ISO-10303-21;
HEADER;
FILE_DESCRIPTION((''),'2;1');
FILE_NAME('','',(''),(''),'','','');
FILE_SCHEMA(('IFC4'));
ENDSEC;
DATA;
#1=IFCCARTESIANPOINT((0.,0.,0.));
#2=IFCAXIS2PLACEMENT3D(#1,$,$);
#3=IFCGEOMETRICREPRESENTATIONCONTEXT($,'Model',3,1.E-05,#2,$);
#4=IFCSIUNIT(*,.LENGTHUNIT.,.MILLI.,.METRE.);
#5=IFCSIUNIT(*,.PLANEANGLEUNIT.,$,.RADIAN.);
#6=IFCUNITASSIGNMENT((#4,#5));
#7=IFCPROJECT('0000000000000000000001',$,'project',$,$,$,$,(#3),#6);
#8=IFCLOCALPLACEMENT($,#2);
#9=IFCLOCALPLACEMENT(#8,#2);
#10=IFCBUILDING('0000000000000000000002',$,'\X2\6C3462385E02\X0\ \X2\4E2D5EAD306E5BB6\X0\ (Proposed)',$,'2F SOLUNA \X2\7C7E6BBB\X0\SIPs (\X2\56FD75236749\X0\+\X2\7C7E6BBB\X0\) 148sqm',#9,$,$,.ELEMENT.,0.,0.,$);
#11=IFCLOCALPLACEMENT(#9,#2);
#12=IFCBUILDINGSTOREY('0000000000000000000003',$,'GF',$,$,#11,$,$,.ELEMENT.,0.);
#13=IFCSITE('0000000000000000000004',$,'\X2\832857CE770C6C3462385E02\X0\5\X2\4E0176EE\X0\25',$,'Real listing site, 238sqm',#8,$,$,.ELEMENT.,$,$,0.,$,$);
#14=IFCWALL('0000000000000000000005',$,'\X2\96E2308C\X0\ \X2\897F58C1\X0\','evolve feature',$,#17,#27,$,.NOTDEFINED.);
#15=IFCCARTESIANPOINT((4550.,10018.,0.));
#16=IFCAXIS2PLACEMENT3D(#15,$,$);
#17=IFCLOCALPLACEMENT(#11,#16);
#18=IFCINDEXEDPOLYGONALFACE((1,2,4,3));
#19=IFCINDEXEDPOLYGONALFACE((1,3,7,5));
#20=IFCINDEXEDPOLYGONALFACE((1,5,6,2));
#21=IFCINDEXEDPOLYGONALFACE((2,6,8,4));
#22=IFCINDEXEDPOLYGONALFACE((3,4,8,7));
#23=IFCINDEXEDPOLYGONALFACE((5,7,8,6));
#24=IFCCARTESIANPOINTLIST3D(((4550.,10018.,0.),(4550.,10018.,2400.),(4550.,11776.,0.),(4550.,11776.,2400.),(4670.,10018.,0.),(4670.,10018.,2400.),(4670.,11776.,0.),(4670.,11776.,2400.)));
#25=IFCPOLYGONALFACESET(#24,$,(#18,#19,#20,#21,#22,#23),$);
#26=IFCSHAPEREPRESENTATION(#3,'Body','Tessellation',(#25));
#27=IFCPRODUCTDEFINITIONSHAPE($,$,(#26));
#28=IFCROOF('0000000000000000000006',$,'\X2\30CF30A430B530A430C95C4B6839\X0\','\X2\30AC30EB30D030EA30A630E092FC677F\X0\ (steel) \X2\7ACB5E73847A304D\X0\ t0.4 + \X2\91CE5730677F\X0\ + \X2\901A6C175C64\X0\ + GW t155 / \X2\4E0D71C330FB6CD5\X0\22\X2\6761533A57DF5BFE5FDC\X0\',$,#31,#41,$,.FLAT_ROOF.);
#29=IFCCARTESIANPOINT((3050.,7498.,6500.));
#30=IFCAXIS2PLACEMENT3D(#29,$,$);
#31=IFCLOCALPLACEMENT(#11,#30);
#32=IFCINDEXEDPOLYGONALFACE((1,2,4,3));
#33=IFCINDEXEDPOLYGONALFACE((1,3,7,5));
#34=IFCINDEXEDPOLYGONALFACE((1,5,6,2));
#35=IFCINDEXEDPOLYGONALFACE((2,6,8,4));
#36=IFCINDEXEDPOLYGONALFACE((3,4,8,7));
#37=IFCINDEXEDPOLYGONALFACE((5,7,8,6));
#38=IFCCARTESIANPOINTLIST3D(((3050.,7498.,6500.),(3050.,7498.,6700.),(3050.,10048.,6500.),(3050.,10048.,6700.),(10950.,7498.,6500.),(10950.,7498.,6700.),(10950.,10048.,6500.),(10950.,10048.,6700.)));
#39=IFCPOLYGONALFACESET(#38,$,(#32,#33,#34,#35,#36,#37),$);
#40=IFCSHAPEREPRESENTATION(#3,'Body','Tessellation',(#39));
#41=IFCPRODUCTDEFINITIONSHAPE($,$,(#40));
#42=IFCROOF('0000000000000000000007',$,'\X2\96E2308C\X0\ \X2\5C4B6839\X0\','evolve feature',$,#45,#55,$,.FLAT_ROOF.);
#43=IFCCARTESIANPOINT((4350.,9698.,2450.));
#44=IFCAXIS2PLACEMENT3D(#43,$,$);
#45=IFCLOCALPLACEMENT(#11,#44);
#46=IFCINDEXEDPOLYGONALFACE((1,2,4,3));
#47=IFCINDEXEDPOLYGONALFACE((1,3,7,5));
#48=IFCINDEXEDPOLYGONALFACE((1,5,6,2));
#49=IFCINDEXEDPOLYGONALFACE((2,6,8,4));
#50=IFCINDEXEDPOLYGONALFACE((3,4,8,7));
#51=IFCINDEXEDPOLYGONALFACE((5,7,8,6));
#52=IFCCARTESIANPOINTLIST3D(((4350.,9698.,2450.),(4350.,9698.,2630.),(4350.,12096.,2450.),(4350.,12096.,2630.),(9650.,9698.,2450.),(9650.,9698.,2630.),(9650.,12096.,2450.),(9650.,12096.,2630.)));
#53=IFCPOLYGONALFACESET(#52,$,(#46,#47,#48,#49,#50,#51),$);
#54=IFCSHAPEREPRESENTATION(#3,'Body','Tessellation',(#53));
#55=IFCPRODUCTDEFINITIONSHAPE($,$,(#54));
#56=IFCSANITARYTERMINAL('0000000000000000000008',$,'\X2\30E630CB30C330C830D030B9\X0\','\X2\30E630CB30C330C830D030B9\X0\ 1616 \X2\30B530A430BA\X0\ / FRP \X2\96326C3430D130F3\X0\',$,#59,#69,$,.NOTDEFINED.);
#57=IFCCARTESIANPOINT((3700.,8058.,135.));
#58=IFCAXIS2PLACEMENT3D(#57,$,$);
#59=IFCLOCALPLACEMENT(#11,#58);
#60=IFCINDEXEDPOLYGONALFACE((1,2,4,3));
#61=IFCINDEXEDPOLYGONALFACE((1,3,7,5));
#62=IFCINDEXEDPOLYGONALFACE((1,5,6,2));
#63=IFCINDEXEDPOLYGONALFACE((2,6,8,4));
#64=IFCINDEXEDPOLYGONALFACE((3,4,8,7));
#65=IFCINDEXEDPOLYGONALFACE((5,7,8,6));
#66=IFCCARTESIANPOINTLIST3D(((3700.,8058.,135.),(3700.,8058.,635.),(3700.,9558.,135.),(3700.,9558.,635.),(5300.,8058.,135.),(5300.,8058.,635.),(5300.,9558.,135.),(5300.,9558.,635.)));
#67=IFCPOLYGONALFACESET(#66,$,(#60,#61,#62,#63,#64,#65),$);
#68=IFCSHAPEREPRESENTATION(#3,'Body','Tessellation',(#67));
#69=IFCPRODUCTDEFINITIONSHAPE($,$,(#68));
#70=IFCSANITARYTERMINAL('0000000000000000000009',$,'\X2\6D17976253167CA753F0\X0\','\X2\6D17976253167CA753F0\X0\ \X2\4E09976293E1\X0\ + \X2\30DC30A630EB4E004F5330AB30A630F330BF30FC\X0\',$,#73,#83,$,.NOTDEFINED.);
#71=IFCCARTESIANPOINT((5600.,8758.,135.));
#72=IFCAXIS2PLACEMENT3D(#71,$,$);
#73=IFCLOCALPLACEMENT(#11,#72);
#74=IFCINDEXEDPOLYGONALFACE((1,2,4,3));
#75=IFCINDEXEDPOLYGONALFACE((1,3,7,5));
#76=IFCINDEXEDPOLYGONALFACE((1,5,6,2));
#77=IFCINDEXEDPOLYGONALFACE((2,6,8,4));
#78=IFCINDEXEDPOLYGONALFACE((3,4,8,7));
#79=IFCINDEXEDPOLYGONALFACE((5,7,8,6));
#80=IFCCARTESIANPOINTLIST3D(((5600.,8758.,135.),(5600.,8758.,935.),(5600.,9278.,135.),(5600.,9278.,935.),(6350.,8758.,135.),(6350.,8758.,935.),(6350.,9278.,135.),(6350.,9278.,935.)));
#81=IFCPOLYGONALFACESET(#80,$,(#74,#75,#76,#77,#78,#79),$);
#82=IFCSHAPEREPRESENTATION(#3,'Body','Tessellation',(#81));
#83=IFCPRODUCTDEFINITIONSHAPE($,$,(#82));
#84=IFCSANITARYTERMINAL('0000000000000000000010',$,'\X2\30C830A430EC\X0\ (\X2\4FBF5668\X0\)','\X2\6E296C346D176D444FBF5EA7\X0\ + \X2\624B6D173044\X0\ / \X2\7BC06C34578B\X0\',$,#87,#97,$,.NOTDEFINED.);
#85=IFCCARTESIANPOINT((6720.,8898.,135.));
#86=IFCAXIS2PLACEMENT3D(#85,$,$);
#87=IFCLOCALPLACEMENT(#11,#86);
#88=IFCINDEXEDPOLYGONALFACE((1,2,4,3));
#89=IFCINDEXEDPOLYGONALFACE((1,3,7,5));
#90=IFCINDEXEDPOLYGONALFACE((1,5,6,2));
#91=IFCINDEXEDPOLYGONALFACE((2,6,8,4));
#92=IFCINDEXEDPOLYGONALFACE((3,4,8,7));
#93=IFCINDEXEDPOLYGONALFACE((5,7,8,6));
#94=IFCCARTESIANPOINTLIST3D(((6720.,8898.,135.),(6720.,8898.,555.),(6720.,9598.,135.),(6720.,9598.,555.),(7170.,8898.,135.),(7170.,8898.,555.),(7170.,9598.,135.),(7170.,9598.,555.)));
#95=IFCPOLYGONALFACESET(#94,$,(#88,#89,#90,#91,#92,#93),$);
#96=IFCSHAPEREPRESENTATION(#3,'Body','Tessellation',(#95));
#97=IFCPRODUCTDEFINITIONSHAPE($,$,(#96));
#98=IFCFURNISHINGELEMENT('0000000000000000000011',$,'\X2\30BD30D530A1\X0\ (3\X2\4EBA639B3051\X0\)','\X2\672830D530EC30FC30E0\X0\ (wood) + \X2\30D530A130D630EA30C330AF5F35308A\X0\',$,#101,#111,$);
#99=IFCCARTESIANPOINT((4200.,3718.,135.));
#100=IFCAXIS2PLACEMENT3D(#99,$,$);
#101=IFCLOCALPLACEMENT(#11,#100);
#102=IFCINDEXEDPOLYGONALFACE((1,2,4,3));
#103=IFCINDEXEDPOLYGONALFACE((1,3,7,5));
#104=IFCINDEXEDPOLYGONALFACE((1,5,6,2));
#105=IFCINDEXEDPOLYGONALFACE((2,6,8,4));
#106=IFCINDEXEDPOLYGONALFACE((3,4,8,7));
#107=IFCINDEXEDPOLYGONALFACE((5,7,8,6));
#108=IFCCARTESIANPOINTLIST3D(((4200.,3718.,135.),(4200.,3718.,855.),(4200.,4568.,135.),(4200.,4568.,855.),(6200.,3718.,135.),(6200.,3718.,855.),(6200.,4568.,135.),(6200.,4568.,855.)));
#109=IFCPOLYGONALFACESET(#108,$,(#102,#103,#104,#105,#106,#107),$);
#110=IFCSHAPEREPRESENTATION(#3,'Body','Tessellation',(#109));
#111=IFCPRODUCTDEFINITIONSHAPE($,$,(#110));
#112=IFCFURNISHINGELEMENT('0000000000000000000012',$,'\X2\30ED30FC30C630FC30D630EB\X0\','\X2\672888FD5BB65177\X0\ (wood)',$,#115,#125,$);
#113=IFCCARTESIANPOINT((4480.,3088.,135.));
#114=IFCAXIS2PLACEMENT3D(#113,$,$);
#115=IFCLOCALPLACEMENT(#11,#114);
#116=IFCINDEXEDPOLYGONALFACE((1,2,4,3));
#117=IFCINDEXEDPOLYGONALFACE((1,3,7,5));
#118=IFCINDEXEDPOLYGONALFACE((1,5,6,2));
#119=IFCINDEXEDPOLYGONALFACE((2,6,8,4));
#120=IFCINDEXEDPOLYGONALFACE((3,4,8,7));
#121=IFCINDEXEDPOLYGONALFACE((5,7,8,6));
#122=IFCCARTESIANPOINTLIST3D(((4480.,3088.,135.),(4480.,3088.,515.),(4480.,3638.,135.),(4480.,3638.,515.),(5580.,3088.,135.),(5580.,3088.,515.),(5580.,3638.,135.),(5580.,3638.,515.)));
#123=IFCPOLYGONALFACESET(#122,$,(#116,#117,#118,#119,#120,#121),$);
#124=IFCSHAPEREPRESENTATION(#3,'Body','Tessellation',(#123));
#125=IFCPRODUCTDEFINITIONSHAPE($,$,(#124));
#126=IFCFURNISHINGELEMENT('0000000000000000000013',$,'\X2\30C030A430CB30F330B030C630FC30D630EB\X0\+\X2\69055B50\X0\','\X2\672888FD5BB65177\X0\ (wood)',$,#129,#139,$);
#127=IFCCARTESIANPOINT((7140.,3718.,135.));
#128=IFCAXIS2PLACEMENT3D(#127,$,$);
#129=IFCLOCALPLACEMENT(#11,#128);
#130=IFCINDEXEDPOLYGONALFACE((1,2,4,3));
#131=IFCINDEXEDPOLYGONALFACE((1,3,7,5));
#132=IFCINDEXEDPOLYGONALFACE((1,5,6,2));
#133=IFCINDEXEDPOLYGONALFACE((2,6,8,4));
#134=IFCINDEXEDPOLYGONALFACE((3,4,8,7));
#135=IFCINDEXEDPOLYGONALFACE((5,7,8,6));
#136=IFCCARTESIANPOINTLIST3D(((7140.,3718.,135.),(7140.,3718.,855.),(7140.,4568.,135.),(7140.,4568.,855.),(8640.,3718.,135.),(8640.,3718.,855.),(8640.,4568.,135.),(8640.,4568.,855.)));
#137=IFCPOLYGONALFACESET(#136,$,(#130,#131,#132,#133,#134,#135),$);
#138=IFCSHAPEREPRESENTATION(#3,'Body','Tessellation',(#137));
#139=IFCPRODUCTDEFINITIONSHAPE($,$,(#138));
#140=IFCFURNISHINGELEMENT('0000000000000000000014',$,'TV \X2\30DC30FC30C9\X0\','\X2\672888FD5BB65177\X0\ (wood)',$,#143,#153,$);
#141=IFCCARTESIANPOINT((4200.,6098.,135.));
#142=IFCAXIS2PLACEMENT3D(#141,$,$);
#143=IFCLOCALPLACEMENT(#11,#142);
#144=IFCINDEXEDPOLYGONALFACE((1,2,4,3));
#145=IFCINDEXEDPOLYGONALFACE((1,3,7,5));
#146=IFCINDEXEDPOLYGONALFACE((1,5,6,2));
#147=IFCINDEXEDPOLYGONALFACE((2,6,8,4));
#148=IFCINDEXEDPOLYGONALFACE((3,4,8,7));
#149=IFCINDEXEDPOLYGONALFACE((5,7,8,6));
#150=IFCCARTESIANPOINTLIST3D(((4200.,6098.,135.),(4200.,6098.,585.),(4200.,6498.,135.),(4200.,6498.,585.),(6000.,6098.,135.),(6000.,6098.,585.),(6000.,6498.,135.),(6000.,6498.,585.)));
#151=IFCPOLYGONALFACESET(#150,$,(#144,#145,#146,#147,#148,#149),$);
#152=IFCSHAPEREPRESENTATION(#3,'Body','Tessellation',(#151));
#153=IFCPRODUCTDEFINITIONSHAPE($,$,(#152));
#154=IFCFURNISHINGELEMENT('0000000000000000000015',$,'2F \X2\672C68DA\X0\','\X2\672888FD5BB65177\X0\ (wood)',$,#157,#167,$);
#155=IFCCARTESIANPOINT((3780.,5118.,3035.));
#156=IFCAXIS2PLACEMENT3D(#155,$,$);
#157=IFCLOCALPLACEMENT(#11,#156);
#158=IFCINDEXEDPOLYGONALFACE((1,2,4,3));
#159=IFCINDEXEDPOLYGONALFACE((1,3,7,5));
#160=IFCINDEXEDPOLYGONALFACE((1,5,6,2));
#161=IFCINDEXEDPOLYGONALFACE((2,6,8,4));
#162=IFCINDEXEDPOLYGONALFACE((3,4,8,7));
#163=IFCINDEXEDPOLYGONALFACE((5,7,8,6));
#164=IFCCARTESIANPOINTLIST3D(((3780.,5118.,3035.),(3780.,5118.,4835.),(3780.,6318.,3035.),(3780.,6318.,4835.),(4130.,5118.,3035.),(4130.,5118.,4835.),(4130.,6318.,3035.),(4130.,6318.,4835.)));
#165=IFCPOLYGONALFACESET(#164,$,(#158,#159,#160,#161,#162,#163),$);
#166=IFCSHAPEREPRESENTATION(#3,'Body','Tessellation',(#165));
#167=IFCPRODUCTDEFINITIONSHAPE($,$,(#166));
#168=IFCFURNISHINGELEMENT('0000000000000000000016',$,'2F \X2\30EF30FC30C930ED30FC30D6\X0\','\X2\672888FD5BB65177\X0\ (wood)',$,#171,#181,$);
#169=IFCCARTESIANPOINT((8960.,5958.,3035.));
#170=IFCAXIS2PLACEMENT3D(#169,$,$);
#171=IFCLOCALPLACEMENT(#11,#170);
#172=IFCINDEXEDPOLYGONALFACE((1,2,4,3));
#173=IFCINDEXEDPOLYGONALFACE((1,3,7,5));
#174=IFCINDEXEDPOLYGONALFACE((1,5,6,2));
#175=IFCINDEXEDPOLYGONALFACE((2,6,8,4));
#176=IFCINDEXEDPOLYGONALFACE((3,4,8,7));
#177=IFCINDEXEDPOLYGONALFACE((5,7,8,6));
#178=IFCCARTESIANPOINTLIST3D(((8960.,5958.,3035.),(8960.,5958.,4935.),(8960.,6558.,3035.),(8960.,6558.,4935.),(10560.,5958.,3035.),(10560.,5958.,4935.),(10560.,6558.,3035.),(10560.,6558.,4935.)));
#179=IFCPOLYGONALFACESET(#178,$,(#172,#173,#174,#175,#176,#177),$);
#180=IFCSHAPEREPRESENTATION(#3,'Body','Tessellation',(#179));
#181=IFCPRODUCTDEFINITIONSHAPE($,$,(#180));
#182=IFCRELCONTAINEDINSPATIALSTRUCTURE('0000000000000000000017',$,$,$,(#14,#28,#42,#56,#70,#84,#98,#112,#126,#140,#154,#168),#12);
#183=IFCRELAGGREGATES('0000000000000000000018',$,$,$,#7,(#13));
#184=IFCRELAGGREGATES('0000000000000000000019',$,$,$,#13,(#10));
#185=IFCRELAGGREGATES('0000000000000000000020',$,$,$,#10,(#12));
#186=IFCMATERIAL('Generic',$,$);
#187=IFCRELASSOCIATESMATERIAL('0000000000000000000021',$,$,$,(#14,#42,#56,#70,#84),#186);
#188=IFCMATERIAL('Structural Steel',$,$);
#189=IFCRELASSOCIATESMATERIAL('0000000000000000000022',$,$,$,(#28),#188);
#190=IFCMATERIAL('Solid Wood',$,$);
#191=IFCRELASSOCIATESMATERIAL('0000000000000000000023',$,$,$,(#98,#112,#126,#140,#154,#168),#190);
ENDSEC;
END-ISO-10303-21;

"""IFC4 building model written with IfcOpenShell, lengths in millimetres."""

from ifc_helpers import new_model, si_unit, frame, frame_2d, origin, place, context, project, spatial, rectangle, extrude, material, element, save


model = new_model("IFC4")

# Units and contexts
model_context = context("Model", 3, precision=1e-05, world=origin())
ifc_project = project(units=[si_unit("LENGTHUNIT", "METRE", prefix="MILLI"), si_unit("PLANEANGLEUNIT", "RADIAN")], contexts=[model_context])

# Site, building, storey
site_placement = place(None, origin())
site = spatial("IfcSite", under=ifc_project, at=site_placement, Name="茨城県水戸市5丁目25", ObjectType="Real listing site, 238sqm", CompositionType="ELEMENT", RefElevation=0.0)
building_placement = place(site_placement, origin())
building = spatial("IfcBuilding", under=site, at=building_placement, Name="水戸市 中庭の家 (Proposed)", ObjectType="2F SOLUNA 籾殻SIPs (国産杉+籾殻) 148sqm", CompositionType="ELEMENT", ElevationOfRefHeight=0.0, ElevationOfTerrain=0.0)
storey_placement = place(building_placement, origin())
storey = spatial("IfcBuildingStorey", under=building, at=storey_placement, Name="GF", CompositionType="ELEMENT", Elevation=0.0)

# Shared definitions
ifc_material_1 = material(Name="Generic")

# Shared definitions
ifc_material_2 = material(Name="Solid Wood")

# Wall
wall_1_placement = place(storey_placement, frame((4550.0, 10018.0, 0.0)))
element("IfcWall", 1, at=wall_1_placement, inside=storey, material=ifc_material_1, Name="離れ 西壁", Description="evolve feature", PredefinedType="NOTDEFINED", context=model_context, shape_type="SweptSolid", body=[
    extrude(rectangle(XDim=120.0, YDim=1758.0, at=frame_2d((60.0, 879.0))), frame((4550.0, 10018.0, 0.0)), (0.0, 0.0, 1.0), 2400.0),
])

# Roofs
ifc_material_3 = material(Name="Structural Steel")
roof_1_placement = place(storey_placement, frame((3050.0, 7498.0, 6500.0)))
element("IfcRoof", 2, at=roof_1_placement, inside=storey, material=ifc_material_3, Name="ハイサイド屋根", Description="ガルバリウム鋼板 (steel) 立平葺き t0.4 + 野地板 + 通気層 + GW t155 / 不燃・法22条区域対応", PredefinedType="FLAT_ROOF", context=model_context, shape_type="SweptSolid", body=[
    extrude(rectangle(XDim=7900.0, YDim=2550.0, at=frame_2d((3950.0, 1275.0))), frame((3050.0, 7498.0, 6500.0)), (0.0, 0.0, 1.0), 200.0),
])
roof_2_placement = place(storey_placement, frame((4350.0, 9698.0, 2450.0)))
element("IfcRoof", 3, at=roof_2_placement, inside=storey, material=ifc_material_1, Name="離れ 屋根", Description="evolve feature", PredefinedType="FLAT_ROOF", context=model_context, shape_type="SweptSolid", body=[
    extrude(rectangle(XDim=5300.0, YDim=2398.0, at=frame_2d((2650.0, 1199.0))), frame((4350.0, 9698.0, 2450.0)), (0.0, 0.0, 1.0), 180.0),
])

# Sanitary terminals
sanitary_terminal_1_placement = place(storey_placement, frame((3700.0, 8058.0, 135.0)))
element("IfcSanitaryTerminal", 4, at=sanitary_terminal_1_placement, inside=storey, material=ifc_material_1, Name="ユニットバス", Description="ユニットバス 1616 サイズ / FRP 防水パン", PredefinedType="NOTDEFINED", context=model_context, shape_type="SweptSolid", body=[
    extrude(rectangle(XDim=1600.0, YDim=1500.0, at=frame_2d((800.0, 750.0))), frame((3700.0, 8058.0, 135.0)), (0.0, 0.0, 1.0), 500.0),
])
sanitary_terminal_2_placement = place(storey_placement, frame((5600.0, 8758.0, 135.0)))
element("IfcSanitaryTerminal", 5, at=sanitary_terminal_2_placement, inside=storey, material=ifc_material_1, Name="洗面化粧台", Description="洗面化粧台 三面鏡 + ボウル一体カウンター", PredefinedType="NOTDEFINED", context=model_context, shape_type="SweptSolid", body=[
    extrude(rectangle(XDim=750.0, YDim=520.0, at=frame_2d((375.0, 260.0))), frame((5600.0, 8758.0, 135.0)), (0.0, 0.0, 1.0), 800.0),
])
sanitary_terminal_3_placement = place(storey_placement, frame((6720.0, 8898.0, 135.0)))
element("IfcSanitaryTerminal", 6, at=sanitary_terminal_3_placement, inside=storey, material=ifc_material_1, Name="トイレ (便器)", Description="温水洗浄便座 + 手洗い / 節水型", PredefinedType="NOTDEFINED", context=model_context, shape_type="SweptSolid", body=[
    extrude(rectangle(XDim=450.0, YDim=700.0, at=frame_2d((225.0, 350.0))), frame((6720.0, 8898.0, 135.0)), (0.0, 0.0, 1.0), 420.0),
])

# Furnishing elements
furnishing_1_placement = place(storey_placement, frame((4200.0, 3718.0, 135.0)))
element("IfcFurnishingElement", 7, at=furnishing_1_placement, inside=storey, material=ifc_material_2, Name="ソファ (3人掛け)", Description="木フレーム (wood) + ファブリック張り", context=model_context, shape_type="SweptSolid", body=[
    extrude(rectangle(XDim=2000.0, YDim=850.0, at=frame_2d((1000.0, 425.0))), frame((4200.0, 3718.0, 135.0)), (0.0, 0.0, 1.0), 720.0),
])
furnishing_2_placement = place(storey_placement, frame((4480.0, 3088.0, 135.0)))
element("IfcFurnishingElement", 8, at=furnishing_2_placement, inside=storey, material=ifc_material_2, Name="ローテーブル", Description="木製家具 (wood)", context=model_context, shape_type="SweptSolid", body=[
    extrude(rectangle(XDim=1100.0, YDim=550.0, at=frame_2d((550.0, 275.0))), frame((4480.0, 3088.0, 135.0)), (0.0, 0.0, 1.0), 380.0),
])
furnishing_3_placement = place(storey_placement, frame((7140.0, 3718.0, 135.0)))
element("IfcFurnishingElement", 9, at=furnishing_3_placement, inside=storey, material=ifc_material_2, Name="ダイニングテーブル+椅子", Description="木製家具 (wood)", context=model_context, shape_type="SweptSolid", body=[
    extrude(rectangle(XDim=1500.0, YDim=850.0, at=frame_2d((750.0, 425.0))), frame((7140.0, 3718.0, 135.0)), (0.0, 0.0, 1.0), 720.0),
])
furnishing_4_placement = place(storey_placement, frame((4200.0, 6098.0, 135.0)))
element("IfcFurnishingElement", 10, at=furnishing_4_placement, inside=storey, material=ifc_material_2, Name="TV ボード", Description="木製家具 (wood)", context=model_context, shape_type="SweptSolid", body=[
    extrude(rectangle(XDim=1800.0, YDim=400.0, at=frame_2d((900.0, 200.0))), frame((4200.0, 6098.0, 135.0)), (0.0, 0.0, 1.0), 450.0),
])
furnishing_5_placement = place(storey_placement, frame((3780.0, 5118.0, 3035.0)))
element("IfcFurnishingElement", 11, at=furnishing_5_placement, inside=storey, material=ifc_material_2, Name="2F 本棚", Description="木製家具 (wood)", context=model_context, shape_type="SweptSolid", body=[
    extrude(rectangle(XDim=350.0, YDim=1200.0, at=frame_2d((175.0, 600.0))), frame((3780.0, 5118.0, 3035.0)), (0.0, 0.0, 1.0), 1800.0),
])
furnishing_6_placement = place(storey_placement, frame((8960.0, 5958.0, 3035.0)))
element("IfcFurnishingElement", 12, at=furnishing_6_placement, inside=storey, material=ifc_material_2, Name="2F ワードローブ", Description="木製家具 (wood)", context=model_context, shape_type="SweptSolid", body=[
    extrude(rectangle(XDim=1600.0, YDim=600.0, at=frame_2d((800.0, 300.0))), frame((8960.0, 5958.0, 3035.0)), (0.0, 0.0, 1.0), 1900.0),
])

save(model, "model.ifc")
